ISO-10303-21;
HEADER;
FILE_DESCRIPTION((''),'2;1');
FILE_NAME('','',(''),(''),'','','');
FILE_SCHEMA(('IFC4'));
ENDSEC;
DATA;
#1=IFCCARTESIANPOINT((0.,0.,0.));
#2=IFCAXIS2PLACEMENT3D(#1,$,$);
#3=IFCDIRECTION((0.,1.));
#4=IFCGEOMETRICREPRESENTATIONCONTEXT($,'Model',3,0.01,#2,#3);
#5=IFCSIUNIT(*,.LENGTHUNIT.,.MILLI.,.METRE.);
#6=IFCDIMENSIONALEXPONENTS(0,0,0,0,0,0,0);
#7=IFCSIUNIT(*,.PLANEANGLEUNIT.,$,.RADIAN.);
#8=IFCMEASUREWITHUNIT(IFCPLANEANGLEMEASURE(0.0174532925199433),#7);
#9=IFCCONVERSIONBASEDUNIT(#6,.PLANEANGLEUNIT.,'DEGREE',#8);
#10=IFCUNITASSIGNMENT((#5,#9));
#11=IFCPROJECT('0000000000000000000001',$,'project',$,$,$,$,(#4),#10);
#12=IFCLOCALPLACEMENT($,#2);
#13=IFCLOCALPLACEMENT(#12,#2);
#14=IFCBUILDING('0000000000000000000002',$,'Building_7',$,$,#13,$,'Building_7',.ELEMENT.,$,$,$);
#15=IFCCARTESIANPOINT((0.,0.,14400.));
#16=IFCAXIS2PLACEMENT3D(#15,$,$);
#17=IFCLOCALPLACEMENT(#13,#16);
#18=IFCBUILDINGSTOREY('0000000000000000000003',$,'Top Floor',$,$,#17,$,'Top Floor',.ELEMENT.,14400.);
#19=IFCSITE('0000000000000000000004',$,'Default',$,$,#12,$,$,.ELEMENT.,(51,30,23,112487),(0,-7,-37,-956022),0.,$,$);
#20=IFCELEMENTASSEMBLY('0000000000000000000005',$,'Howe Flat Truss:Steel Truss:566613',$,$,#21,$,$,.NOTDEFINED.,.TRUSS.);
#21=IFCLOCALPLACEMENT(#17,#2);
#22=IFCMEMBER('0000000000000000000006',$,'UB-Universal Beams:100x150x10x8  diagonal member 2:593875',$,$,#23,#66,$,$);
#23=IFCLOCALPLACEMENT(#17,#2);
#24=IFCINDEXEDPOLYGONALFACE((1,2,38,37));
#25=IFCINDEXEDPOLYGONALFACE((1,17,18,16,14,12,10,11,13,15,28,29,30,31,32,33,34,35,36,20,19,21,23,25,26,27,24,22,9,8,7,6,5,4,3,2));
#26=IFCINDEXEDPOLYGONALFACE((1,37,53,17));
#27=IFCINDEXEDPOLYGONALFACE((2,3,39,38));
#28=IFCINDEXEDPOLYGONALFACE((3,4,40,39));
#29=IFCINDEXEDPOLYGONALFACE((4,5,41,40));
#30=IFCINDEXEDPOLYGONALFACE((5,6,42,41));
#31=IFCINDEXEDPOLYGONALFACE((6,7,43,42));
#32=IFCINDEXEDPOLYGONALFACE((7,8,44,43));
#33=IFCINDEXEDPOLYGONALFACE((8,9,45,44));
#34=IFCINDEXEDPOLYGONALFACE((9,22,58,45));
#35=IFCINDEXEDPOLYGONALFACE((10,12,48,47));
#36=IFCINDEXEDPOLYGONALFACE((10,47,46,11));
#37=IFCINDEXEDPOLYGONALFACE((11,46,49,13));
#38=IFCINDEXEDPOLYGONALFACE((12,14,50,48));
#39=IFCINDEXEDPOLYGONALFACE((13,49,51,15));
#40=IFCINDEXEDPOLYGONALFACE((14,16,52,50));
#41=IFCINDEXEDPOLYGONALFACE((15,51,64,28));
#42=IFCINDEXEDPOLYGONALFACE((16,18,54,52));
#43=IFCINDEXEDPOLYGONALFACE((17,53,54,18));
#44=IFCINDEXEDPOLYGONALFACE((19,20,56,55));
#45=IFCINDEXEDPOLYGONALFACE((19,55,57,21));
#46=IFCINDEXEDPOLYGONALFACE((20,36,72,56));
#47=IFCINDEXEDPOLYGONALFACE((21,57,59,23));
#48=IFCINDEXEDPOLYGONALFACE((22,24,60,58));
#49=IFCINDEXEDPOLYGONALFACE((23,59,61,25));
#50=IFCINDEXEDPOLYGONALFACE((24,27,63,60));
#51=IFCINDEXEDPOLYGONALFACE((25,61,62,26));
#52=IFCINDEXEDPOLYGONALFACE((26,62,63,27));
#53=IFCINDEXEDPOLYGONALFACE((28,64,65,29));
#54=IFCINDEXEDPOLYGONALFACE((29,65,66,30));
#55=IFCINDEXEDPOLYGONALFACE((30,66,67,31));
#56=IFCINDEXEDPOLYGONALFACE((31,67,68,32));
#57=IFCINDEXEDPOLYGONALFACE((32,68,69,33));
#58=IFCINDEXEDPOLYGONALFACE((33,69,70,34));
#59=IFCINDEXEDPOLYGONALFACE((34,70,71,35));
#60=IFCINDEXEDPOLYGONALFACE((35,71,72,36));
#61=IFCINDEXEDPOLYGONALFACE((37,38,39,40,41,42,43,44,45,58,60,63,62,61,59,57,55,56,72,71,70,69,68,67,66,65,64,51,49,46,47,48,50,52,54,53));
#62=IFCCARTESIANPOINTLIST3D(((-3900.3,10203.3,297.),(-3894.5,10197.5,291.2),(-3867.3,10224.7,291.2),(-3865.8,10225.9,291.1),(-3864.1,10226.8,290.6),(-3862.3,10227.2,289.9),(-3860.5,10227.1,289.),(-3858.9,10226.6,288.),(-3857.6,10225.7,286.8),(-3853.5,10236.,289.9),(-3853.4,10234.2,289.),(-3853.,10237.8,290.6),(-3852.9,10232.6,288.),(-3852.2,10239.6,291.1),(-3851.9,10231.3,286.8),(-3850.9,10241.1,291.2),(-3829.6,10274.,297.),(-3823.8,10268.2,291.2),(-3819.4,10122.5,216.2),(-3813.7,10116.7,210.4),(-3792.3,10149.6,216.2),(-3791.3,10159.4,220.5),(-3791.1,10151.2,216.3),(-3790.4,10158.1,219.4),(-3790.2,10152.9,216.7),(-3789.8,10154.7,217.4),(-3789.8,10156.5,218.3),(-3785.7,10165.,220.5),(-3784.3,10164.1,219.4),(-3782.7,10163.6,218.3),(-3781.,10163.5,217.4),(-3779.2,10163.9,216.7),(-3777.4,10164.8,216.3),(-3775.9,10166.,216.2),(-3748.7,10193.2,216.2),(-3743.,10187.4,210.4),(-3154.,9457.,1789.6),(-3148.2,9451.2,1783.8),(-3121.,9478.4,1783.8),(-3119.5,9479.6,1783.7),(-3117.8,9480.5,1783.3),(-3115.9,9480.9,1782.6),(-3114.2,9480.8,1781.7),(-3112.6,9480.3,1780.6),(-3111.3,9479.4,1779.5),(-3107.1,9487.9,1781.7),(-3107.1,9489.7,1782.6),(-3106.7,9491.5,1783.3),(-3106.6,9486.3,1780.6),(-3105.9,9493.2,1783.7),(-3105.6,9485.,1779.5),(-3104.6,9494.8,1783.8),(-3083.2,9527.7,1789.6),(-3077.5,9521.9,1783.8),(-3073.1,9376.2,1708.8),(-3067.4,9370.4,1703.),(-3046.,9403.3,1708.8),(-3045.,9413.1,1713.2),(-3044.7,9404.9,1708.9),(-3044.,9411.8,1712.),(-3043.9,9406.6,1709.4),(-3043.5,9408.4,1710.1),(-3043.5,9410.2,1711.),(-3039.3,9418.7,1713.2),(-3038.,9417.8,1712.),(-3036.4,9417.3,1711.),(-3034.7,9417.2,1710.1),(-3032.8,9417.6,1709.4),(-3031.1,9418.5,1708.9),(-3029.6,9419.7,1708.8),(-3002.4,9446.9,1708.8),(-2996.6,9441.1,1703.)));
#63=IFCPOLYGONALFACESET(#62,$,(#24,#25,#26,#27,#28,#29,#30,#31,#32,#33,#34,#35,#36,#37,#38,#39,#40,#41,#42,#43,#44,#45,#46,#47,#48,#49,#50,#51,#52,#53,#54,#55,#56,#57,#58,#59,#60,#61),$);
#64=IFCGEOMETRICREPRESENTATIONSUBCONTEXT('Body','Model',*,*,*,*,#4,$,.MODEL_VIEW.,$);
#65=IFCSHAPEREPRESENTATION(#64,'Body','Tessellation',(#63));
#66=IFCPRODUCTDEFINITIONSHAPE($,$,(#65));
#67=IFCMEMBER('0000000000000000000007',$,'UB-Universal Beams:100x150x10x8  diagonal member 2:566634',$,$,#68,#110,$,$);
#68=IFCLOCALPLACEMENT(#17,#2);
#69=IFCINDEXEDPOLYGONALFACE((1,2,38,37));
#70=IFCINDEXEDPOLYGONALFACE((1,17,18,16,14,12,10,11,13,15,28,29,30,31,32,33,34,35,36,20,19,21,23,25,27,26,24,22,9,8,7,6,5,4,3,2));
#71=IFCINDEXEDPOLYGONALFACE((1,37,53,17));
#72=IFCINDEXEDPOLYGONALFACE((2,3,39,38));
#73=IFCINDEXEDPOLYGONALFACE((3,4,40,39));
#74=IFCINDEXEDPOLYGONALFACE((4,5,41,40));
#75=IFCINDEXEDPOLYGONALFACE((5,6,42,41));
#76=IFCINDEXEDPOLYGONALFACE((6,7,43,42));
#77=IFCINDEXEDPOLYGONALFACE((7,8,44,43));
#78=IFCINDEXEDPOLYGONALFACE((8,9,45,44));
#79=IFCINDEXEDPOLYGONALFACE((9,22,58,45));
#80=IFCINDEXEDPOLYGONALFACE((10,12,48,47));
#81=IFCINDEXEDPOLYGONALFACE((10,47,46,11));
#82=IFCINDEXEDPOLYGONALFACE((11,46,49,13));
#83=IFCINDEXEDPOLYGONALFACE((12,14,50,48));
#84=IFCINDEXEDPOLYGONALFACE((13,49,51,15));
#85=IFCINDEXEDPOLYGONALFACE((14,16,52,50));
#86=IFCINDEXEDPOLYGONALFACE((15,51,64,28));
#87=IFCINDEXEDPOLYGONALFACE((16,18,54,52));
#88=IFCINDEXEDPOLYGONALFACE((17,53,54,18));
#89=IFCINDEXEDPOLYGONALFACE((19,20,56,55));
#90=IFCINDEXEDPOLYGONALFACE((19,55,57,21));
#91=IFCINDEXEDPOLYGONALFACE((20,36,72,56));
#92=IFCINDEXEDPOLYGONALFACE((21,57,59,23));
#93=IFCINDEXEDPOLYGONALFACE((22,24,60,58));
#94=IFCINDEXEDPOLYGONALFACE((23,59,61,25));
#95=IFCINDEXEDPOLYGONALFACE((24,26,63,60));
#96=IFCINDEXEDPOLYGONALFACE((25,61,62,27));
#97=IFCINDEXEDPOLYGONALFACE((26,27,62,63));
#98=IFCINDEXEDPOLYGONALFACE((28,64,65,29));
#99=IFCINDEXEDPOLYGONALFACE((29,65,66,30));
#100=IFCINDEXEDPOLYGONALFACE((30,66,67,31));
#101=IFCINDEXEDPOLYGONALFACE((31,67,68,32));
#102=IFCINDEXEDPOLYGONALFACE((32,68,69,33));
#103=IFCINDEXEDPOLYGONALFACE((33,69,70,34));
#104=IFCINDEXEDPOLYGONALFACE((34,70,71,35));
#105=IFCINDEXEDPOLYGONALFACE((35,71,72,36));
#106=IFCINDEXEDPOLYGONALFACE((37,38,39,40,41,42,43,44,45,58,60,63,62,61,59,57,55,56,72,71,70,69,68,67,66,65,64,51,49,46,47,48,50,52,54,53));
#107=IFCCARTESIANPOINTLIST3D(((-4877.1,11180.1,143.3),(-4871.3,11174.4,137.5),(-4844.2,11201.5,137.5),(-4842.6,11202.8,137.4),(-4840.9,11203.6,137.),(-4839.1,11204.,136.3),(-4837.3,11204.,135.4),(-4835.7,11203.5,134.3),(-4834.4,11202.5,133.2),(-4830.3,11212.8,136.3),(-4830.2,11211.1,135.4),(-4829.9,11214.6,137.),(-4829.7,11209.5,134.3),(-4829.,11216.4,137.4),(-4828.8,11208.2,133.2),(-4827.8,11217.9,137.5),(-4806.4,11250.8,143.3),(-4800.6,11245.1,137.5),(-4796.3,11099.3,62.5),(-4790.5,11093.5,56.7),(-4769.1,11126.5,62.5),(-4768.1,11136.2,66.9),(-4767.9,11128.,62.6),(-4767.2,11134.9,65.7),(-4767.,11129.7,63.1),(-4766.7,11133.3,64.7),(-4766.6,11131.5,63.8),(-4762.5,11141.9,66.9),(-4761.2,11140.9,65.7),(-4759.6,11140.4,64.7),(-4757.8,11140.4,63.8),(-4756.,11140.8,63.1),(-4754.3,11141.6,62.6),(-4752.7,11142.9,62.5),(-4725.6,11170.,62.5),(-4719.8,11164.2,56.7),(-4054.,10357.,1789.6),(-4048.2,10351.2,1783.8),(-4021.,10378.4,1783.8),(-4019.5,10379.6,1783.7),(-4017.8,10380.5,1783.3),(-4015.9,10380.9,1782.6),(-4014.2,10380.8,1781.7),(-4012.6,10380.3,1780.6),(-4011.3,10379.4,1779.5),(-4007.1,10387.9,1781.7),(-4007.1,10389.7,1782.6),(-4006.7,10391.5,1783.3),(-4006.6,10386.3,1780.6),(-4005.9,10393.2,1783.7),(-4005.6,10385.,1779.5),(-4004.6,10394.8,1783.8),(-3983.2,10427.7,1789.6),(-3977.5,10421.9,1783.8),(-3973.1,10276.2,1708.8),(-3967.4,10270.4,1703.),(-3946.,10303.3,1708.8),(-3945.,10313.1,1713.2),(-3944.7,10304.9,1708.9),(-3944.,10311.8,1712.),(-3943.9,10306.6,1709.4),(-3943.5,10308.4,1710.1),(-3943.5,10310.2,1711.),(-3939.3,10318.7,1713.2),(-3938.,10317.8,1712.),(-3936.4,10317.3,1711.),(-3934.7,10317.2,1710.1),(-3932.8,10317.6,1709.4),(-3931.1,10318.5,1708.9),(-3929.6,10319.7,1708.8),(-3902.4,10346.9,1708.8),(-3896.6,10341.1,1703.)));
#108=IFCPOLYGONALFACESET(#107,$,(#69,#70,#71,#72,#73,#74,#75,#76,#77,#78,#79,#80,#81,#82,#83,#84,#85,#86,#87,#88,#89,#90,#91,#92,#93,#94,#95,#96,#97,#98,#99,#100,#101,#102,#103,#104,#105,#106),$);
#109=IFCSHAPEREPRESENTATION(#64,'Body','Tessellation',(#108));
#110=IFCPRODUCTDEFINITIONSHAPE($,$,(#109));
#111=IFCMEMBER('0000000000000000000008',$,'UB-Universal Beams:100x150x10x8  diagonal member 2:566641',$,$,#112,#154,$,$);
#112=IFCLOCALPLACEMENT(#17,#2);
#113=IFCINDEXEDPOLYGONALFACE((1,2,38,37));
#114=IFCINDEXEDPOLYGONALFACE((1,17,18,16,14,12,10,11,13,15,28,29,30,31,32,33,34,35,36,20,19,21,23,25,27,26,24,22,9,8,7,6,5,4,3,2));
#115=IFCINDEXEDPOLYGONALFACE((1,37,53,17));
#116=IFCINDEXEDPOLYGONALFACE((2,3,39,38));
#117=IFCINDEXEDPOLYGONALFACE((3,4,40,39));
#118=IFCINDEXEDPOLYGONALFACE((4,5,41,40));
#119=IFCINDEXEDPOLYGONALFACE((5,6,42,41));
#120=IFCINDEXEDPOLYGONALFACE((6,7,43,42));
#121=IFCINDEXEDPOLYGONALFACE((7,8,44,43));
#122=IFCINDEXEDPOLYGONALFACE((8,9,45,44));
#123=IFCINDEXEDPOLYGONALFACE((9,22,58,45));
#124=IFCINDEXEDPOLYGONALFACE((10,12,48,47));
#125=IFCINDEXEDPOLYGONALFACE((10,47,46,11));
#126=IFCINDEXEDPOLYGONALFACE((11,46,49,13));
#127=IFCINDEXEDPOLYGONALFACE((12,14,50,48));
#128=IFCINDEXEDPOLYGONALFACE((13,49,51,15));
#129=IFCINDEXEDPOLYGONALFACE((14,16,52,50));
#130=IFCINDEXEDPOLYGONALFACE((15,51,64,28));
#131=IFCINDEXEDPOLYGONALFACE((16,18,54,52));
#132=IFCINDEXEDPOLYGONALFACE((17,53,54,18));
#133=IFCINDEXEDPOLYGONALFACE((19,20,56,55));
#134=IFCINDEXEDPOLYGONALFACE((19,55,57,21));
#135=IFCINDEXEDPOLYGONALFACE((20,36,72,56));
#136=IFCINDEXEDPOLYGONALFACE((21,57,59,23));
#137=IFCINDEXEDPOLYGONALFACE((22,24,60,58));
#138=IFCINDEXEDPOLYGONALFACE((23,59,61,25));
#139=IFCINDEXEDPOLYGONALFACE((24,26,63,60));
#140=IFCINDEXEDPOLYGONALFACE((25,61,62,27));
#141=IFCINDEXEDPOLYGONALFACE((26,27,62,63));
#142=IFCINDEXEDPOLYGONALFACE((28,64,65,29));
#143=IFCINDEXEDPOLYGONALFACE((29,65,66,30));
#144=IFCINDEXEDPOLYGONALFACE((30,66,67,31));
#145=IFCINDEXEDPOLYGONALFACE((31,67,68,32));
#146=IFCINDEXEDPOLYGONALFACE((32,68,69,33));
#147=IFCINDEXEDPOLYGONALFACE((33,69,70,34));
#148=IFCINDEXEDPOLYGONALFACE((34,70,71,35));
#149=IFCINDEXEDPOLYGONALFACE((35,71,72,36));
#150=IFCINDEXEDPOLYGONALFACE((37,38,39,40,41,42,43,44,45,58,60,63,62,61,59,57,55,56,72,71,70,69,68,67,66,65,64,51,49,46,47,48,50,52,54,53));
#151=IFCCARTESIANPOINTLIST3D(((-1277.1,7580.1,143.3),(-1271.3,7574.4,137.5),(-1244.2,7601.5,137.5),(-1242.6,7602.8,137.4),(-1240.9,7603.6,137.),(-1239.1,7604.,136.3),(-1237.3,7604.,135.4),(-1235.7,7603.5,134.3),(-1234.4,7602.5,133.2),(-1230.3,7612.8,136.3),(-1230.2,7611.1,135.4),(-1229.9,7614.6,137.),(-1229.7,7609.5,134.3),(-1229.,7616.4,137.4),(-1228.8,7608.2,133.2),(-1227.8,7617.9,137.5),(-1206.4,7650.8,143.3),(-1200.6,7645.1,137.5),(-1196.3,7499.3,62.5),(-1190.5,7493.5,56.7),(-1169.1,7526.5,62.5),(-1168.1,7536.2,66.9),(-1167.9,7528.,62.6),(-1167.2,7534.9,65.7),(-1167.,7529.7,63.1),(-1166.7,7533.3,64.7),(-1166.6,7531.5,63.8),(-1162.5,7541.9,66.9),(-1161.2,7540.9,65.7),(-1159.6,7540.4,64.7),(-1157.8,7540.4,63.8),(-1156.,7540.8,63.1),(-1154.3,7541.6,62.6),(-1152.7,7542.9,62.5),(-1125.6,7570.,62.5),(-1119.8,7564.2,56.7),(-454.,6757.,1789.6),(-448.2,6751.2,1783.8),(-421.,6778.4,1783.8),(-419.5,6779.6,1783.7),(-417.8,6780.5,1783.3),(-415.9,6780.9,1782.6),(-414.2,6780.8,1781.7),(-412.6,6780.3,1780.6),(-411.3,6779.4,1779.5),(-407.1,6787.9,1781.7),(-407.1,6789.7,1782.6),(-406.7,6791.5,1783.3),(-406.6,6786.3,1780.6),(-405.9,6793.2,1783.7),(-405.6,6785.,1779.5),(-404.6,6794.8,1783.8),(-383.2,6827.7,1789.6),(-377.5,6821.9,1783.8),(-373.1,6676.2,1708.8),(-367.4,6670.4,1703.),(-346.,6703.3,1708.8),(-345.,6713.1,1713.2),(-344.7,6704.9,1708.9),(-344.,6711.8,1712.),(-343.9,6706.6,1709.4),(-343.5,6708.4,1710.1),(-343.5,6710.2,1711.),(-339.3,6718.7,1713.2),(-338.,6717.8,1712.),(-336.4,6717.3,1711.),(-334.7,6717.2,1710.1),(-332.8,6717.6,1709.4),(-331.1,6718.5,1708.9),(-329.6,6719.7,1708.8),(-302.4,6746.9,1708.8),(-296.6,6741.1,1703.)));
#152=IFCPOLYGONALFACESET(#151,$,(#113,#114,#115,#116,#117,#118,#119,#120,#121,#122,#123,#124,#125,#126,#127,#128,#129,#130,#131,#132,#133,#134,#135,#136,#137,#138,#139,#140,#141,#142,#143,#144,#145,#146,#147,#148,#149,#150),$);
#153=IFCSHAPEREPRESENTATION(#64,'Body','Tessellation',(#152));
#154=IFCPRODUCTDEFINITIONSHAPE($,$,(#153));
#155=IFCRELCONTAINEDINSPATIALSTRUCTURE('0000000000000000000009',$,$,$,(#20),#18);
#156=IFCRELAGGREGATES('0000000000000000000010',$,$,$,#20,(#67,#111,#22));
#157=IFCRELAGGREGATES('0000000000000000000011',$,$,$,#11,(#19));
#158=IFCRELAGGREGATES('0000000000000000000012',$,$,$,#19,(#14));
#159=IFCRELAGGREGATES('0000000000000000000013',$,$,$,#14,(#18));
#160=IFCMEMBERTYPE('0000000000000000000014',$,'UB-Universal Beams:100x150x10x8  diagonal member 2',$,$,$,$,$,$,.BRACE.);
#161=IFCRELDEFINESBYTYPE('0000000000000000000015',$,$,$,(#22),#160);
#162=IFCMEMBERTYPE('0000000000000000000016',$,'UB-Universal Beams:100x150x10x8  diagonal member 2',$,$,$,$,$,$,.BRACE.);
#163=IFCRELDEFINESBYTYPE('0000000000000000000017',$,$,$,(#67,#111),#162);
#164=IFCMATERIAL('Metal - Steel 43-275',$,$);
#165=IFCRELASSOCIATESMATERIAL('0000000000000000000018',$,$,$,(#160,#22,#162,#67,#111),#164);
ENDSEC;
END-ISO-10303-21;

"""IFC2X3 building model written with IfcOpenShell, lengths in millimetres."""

from ifc_helpers import new_model, entity, si_unit, converted_unit, direction, frame, frame_2d, origin, place, context, subcontext, project, spatial, polyline, circle_curve, parameter, trimmed, segment, composite_curve, outline, extrude, source, transform, mapped, material, type_object, type_shapes, element, aggregate, save


model = new_model("IFC2X3")

# Units and contexts
model_context = context("Model", 3, precision=0.01, world=origin(), true_north=direction((0.0, 1.0)))
body_context = subcontext(model_context, "Body", "Model", "MODEL_VIEW")
ifc_project = project(units=[si_unit("LENGTHUNIT", "METRE", prefix="MILLI"), converted_unit("PLANEANGLEUNIT", "DEGREE", entity("IfcPlaneAngleMeasure", 0.0174532925199433), si_unit("PLANEANGLEUNIT", "RADIAN"), dimensions=[0, 0, 0, 0, 0, 0, 0])], contexts=[model_context])

# Site, building, storey
site_placement = place(None, origin())
site = spatial("IfcSite", under=ifc_project, at=site_placement, Name="Default", CompositionType="ELEMENT", RefLatitude=(51, 30, 23, 112487), RefLongitude=(0, -7, -37, -956022), RefElevation=0.0)
building_placement = place(site_placement, origin())
building = spatial("IfcBuilding", under=site, at=building_placement, Name="Building_7", LongName="Building_7", CompositionType="ELEMENT")
storey_placement = place(building_placement, frame((0.0, 0.0, 14400.0)))
storey = spatial("IfcBuildingStorey", under=building, at=storey_placement, Name="Top Floor", LongName="Top Floor", CompositionType="ELEMENT", Elevation=14400.0)

# Shared definitions
ifc_material = material(Name="Metal - Steel 43-275")

# Element assembly
assembly_1_placement = place(storey_placement, origin())
assembly_1 = element("IfcElementAssembly", 1, at=assembly_1_placement, inside=storey, Name="Howe Flat Truss:Steel Truss:566613", AssemblyPlace="NOTDEFINED", PredefinedType="TRUSS")

# Members
member_type_1 = type_object("IfcMemberType", Name="UB-Universal Beams:100x150x10x8  diagonal member 2", PredefinedType="BRACE", material=ifc_material)
shared_shape_1 = source(origin(), body_context, "Body", "SweptSolid", [
    extrude(outline(composite_curve([segment(polyline([(-50.0, -65.0), (-50.0, -75.0)]), True, "CONTINUOUS"), segment(polyline([(-50.0, -75.0), (50.0, -75.0)]), True, "CONTINUOUS"), segment(polyline([(50.0, -75.0), (50.0, -65.0)]), True, "CONTINUOUS"), segment(polyline([(50.0, -65.0), (11.6, -65.0)]), True, "CONTINUOUS"), segment(trimmed(circle_curve(frame_2d((11.6, -57.4), x_axis=(1.0, 0.0)), 7.6), [parameter(180.0)], [parameter(270.0)], True, "PARAMETER"), False, "CONTINUOUS"), segment(polyline([(4.0, -57.4), (4.0, 57.4)]), True, "CONTINUOUS"), segment(trimmed(circle_curve(frame_2d((11.6, 57.4), x_axis=(1.0, 0.0)), 7.6), [parameter(90.0)], [parameter(180.0)], True, "PARAMETER"), False, "CONTINUOUS"), segment(polyline([(11.6, 65.0), (50.0, 65.0)]), True, "CONTINUOUS"), segment(polyline([(50.0, 65.0), (50.0, 75.0)]), True, "CONTINUOUS"), segment(polyline([(50.0, 75.0), (-50.0, 75.0)]), True, "CONTINUOUS"), segment(polyline([(-50.0, 75.0), (-50.0, 65.0)]), True, "CONTINUOUS"), segment(polyline([(-50.0, 65.0), (-11.6, 65.0)]), True, "CONTINUOUS"), segment(trimmed(circle_curve(frame_2d((-11.6, 57.4), x_axis=(1.0, 0.0)), 7.6), [parameter(360.0)], [parameter(90.0)], True, "PARAMETER"), False, "CONTINUOUS"), segment(polyline([(-4.0, 57.4), (-4.0, -57.4)]), True, "CONTINUOUS"), segment(trimmed(circle_curve(frame_2d((-11.6, -57.4), x_axis=(1.0, 0.0)), 7.6), [parameter(270.0)], [parameter(360.0)], True, "PARAMETER"), False, "CONTINUOUS"), segment(polyline([(-11.6, -65.0), (-50.0, -65.0)]), True, "CONTINUOUS")], self_intersect=False)), frame((-914.0, 0.0, 0.0), z_axis=(-1.0, 0.0, 0.0), x_axis=(0.0, -1.0, 0.0)), (0.0, 0.0, -1.0), 1828.1),
])
type_shapes(member_type_1, [shared_shape_1])
member_1_placement = place(assembly_1_placement, frame((-3448.5, 9822.2, 1000.0), z_axis=(0.57735, -0.57735, -0.57735), x_axis=(0.408248, -0.408248, 0.816497)))
member_1 = element("IfcMember", 2, at=member_1_placement, type_object=member_type_1, material=ifc_material, Name="UB-Universal Beams:100x150x10x8  diagonal member 2:593875", context=body_context, shape_type="MappedRepresentation", body=[
    mapped(shared_shape_1, transform((0.0, 0.0, 0.0), scale=1.0)),
])
member_type_2 = type_object("IfcMemberType", Name="UB-Universal Beams:100x150x10x8  diagonal member 2", PredefinedType="BRACE", material=ifc_material)
shared_shape_2 = source(origin(), body_context, "Body", "SweptSolid", [
    extrude(outline(composite_curve([segment(polyline([(-50.0, -65.0), (-50.0, -75.0)]), True, "CONTINUOUS"), segment(polyline([(-50.0, -75.0), (50.0, -75.0)]), True, "CONTINUOUS"), segment(polyline([(50.0, -75.0), (50.0, -65.0)]), True, "CONTINUOUS"), segment(polyline([(50.0, -65.0), (11.6, -65.0)]), True, "CONTINUOUS"), segment(trimmed(circle_curve(frame_2d((11.6, -57.4), x_axis=(1.0, 0.0)), 7.6), [parameter(180.0)], [parameter(270.0)], True, "PARAMETER"), False, "CONTINUOUS"), segment(polyline([(4.0, -57.4), (4.0, 57.4)]), True, "CONTINUOUS"), segment(trimmed(circle_curve(frame_2d((11.6, 57.4), x_axis=(1.0, 0.0)), 7.6), [parameter(90.0)], [parameter(180.0)], True, "PARAMETER"), False, "CONTINUOUS"), segment(polyline([(11.6, 65.0), (50.0, 65.0)]), True, "CONTINUOUS"), segment(polyline([(50.0, 65.0), (50.0, 75.0)]), True, "CONTINUOUS"), segment(polyline([(50.0, 75.0), (-50.0, 75.0)]), True, "CONTINUOUS"), segment(polyline([(-50.0, 75.0), (-50.0, 65.0)]), True, "CONTINUOUS"), segment(polyline([(-50.0, 65.0), (-11.6, 65.0)]), True, "CONTINUOUS"), segment(trimmed(circle_curve(frame_2d((-11.6, 57.4), x_axis=(1.0, 0.0)), 7.6), [parameter(360.0)], [parameter(90.0)], True, "PARAMETER"), False, "CONTINUOUS"), segment(polyline([(-4.0, 57.4), (-4.0, -57.4)]), True, "CONTINUOUS"), segment(trimmed(circle_curve(frame_2d((-11.6, -57.4), x_axis=(1.0, 0.0)), 7.6), [parameter(270.0)], [parameter(360.0)], True, "PARAMETER"), False, "CONTINUOUS"), segment(polyline([(-11.6, -65.0), (-50.0, -65.0)]), True, "CONTINUOUS")], self_intersect=False)), frame((-1102.2, 0.0, 0.0), z_axis=(-1.0, 0.0, 0.0), x_axis=(0.0, -1.0, 0.0)), (0.0, 0.0, -1.0), 2016.3),
])
type_shapes(member_type_2, [shared_shape_2])
member_2_placement = place(assembly_1_placement, frame((-4348.5, 10722.2, 1000.0), z_axis=(0.57735, -0.57735, -0.57735), x_axis=(0.408248, -0.408248, 0.816497)))
member_2 = element("IfcMember", 3, at=member_2_placement, type_object=member_type_2, material=ifc_material, Name="UB-Universal Beams:100x150x10x8  diagonal member 2:566634", context=body_context, shape_type="MappedRepresentation", body=[
    mapped(shared_shape_2, transform((0.0, 0.0, 0.0), scale=1.0)),
])
member_3_placement = place(assembly_1_placement, frame((-748.5, 7122.2, 1000.0), z_axis=(0.57735, -0.57735, -0.57735), x_axis=(0.408248, -0.408248, 0.816497)))
member_3 = element("IfcMember", 4, at=member_3_placement, type_object=member_type_2, material=ifc_material, Name="UB-Universal Beams:100x150x10x8  diagonal member 2:566641", context=body_context, shape_type="MappedRepresentation", body=[
    mapped(shared_shape_2, transform((0.0, 0.0, 0.0), scale=1.0)),
])
aggregate(assembly_1, [member_2, member_3, member_1])

save(model, "model.ifc")
